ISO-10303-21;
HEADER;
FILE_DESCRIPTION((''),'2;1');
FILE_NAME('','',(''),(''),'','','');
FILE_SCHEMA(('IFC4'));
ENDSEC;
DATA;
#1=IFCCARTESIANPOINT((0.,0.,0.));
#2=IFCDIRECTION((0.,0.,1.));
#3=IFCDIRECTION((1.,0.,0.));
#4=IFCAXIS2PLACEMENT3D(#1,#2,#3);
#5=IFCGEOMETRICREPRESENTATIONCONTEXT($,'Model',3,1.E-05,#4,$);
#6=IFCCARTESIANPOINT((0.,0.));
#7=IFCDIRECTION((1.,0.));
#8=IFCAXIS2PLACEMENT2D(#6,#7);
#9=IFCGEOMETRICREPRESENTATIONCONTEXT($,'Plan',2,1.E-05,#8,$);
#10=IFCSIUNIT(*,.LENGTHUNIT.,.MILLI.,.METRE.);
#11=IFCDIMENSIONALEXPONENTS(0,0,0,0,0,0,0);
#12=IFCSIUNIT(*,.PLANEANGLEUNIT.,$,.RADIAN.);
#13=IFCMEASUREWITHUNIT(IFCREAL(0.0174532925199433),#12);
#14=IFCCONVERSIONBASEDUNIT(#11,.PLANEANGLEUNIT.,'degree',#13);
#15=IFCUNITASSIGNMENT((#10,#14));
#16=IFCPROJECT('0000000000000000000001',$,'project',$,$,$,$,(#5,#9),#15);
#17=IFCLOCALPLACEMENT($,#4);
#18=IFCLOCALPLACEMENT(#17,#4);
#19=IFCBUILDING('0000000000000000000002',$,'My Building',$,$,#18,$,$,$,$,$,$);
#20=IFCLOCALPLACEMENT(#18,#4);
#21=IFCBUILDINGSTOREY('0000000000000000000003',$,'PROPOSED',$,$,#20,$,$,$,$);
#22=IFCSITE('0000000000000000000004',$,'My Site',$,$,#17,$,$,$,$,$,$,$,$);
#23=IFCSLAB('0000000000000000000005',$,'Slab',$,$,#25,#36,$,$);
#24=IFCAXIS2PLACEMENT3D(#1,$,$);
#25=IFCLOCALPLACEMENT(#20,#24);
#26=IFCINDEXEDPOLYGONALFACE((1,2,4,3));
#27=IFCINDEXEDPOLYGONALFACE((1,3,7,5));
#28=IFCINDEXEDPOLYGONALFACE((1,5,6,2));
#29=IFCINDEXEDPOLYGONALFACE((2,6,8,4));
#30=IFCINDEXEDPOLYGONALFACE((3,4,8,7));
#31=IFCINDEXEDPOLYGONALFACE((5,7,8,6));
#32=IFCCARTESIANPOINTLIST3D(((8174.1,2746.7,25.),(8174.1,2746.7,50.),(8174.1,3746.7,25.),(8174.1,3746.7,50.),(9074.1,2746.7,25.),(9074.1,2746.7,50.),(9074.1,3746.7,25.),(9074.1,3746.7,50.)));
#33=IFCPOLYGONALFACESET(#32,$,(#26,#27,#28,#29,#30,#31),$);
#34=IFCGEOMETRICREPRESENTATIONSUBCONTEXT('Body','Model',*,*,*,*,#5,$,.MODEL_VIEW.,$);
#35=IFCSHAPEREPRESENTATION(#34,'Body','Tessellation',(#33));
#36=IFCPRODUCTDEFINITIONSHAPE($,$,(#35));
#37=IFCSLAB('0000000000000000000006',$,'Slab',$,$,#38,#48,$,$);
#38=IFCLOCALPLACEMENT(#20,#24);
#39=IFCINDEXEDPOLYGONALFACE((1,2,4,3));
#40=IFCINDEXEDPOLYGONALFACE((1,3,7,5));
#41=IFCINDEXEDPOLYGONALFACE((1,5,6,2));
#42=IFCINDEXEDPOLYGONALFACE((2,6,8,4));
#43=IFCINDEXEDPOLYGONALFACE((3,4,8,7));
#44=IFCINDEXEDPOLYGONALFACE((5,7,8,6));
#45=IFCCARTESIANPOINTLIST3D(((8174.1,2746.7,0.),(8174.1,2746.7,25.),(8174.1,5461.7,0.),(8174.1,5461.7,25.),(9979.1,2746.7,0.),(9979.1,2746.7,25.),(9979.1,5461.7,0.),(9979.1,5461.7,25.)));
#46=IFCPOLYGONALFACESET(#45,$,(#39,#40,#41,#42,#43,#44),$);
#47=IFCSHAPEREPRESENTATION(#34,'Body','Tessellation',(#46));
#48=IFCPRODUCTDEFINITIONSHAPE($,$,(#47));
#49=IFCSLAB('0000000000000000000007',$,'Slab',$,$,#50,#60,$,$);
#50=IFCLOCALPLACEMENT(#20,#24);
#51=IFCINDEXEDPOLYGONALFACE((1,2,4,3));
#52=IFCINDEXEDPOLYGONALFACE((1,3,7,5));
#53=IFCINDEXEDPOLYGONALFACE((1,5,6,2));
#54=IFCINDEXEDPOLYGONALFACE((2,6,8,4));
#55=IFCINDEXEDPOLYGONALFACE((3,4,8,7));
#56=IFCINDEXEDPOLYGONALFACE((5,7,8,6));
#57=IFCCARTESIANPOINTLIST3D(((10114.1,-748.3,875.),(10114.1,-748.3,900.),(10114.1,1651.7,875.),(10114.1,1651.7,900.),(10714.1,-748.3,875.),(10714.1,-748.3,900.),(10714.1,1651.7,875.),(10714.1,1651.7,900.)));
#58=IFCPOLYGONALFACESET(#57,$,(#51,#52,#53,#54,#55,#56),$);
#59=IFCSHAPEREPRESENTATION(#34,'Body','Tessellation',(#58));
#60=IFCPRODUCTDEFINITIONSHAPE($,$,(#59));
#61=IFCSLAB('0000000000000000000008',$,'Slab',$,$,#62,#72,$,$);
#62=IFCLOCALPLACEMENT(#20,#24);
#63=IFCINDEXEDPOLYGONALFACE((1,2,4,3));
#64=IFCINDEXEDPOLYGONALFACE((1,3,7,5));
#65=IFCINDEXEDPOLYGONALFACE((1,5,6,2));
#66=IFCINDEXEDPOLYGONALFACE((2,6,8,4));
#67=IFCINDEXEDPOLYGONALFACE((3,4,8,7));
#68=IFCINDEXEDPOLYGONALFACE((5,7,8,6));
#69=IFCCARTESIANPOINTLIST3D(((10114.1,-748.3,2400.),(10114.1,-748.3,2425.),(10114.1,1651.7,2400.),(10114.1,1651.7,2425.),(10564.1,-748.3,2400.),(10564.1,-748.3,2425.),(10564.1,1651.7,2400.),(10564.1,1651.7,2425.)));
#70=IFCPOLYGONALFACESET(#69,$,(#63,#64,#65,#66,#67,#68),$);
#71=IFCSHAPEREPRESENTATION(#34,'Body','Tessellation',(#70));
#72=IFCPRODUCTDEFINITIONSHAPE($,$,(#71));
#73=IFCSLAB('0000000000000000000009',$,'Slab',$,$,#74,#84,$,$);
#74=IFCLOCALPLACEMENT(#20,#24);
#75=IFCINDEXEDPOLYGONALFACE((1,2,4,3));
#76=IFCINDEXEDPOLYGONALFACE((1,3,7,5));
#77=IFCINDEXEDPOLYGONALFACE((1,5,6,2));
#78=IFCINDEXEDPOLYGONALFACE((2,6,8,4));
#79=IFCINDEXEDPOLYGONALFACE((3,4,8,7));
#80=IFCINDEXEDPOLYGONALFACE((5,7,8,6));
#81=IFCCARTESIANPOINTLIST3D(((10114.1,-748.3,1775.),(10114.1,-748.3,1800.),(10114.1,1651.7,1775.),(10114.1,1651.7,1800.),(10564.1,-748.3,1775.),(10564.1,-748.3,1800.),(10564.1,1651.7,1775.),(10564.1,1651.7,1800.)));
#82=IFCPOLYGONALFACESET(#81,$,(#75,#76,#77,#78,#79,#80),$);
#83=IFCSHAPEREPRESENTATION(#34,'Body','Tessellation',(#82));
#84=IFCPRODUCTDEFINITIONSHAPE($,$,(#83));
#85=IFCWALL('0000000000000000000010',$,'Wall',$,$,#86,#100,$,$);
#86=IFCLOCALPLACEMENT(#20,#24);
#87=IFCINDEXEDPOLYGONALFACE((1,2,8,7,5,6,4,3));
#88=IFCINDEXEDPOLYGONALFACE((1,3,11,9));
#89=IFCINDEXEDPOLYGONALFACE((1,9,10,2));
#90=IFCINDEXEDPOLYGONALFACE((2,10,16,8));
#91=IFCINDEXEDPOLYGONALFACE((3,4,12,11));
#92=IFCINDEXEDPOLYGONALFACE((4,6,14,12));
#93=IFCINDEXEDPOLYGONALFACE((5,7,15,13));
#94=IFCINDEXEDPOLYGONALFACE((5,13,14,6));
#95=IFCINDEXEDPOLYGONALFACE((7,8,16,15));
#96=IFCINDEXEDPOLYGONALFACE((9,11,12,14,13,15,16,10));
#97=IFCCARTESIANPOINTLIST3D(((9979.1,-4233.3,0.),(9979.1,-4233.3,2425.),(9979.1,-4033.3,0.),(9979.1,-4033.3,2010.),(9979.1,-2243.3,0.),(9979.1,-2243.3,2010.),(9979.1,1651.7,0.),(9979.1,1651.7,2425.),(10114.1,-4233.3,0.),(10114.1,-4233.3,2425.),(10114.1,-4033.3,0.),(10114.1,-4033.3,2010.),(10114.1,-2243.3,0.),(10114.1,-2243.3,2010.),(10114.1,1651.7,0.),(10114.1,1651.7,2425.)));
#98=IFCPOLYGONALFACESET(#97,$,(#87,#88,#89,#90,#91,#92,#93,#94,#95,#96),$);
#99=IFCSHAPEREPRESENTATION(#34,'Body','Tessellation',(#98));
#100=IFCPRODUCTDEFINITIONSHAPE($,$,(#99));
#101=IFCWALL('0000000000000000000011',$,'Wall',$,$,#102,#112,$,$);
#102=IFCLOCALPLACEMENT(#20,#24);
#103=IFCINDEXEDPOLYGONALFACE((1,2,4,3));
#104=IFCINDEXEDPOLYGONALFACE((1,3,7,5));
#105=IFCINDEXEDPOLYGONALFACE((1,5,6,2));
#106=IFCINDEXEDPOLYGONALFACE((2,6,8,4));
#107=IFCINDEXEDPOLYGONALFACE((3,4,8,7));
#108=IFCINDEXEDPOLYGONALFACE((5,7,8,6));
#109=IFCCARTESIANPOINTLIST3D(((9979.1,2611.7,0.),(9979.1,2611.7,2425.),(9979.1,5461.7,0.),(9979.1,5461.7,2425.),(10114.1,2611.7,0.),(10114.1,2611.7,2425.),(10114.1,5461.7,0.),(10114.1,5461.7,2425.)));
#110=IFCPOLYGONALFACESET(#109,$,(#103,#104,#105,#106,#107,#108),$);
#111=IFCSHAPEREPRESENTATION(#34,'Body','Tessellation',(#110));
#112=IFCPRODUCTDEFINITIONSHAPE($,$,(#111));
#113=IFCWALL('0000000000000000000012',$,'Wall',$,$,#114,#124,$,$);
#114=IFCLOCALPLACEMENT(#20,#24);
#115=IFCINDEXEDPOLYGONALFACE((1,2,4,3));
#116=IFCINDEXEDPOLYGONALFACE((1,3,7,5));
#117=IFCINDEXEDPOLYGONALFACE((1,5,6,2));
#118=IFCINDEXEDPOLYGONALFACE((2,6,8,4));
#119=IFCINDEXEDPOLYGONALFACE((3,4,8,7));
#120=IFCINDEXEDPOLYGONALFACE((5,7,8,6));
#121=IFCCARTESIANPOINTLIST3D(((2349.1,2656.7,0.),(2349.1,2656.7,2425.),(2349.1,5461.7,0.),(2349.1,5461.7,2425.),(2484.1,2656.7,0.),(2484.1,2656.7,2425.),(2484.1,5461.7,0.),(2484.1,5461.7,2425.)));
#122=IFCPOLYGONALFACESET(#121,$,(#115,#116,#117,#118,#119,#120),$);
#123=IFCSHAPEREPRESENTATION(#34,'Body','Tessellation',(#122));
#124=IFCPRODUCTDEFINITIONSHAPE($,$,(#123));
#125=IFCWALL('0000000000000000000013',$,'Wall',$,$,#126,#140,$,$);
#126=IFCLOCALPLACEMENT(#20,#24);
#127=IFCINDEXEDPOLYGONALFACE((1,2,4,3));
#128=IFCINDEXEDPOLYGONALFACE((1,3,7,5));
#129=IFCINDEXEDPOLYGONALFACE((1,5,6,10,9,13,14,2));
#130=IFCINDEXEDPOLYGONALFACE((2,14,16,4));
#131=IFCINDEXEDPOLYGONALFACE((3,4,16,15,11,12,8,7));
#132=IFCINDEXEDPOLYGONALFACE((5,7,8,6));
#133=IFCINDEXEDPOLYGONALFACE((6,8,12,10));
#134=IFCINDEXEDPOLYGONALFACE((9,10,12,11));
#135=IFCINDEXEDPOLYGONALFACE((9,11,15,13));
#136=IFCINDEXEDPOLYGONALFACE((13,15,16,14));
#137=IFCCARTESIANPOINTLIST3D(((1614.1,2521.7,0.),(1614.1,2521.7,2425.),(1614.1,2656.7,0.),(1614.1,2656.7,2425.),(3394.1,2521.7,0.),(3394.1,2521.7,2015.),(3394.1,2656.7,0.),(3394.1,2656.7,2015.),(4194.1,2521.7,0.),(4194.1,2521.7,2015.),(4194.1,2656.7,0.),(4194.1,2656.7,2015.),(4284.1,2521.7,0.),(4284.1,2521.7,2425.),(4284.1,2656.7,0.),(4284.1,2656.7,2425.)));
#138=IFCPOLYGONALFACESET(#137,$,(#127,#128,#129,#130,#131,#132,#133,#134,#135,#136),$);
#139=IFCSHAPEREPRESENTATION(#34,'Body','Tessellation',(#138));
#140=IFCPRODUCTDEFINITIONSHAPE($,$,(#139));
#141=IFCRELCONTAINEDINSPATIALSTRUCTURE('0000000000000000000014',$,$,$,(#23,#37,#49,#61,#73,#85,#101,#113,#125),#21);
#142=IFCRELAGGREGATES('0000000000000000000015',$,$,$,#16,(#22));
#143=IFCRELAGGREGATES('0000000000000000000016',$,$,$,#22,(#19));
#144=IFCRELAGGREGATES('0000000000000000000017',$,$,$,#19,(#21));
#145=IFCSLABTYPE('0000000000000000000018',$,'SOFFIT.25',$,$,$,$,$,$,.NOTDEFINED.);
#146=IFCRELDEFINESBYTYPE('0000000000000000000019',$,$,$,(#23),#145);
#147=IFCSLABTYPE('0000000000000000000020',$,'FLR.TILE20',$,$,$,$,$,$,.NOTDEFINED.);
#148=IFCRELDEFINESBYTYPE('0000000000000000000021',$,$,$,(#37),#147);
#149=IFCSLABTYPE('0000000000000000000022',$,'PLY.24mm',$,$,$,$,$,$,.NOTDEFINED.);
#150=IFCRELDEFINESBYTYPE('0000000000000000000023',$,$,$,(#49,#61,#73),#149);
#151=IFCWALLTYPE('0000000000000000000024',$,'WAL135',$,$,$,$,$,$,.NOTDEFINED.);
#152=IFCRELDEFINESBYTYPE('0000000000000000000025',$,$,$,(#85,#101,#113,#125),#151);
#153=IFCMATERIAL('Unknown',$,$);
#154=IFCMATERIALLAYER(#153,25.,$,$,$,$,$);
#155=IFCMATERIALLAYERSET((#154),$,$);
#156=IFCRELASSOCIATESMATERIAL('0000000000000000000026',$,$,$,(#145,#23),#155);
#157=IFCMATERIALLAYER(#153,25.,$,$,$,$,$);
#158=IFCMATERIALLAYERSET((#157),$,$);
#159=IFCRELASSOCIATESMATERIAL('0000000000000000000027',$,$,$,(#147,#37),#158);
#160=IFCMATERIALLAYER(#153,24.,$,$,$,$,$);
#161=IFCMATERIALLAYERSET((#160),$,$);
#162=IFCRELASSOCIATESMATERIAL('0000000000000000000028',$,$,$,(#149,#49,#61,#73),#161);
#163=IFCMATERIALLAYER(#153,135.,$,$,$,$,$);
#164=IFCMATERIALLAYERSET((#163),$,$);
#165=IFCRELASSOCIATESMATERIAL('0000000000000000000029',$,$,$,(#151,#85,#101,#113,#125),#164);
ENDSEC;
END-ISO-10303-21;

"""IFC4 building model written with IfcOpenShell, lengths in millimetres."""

from ifc_helpers import new_model, entity, si_unit, converted_unit, frame, origin_with_axes, origin_2d_with_axis, place, context, subcontext, project, spatial, line, indexed_curve, outline, extrude, source, transform, mapped, material, layer, layer_set, layer_usage, type_object, element, save


model = new_model("IFC4")

# Units and contexts
model_context = context("Model", 3, precision=1e-05, world=origin_with_axes())
plan_context = context("Plan", 2, precision=1e-05, world=origin_2d_with_axis())
body_context_1 = subcontext(model_context, "Body", "Model", "MODEL_VIEW")
ifc_project = project(units=[si_unit("LENGTHUNIT", "METRE", prefix="MILLI"), converted_unit("PLANEANGLEUNIT", "degree", entity("IfcReal", 0.0174532925199433), si_unit("PLANEANGLEUNIT", "RADIAN"), dimensions=[0, 0, 0, 0, 0, 0, 0])], contexts=[model_context, plan_context])

# Site, building, storey
site_placement = place(None, origin_with_axes())
site = spatial("IfcSite", under=ifc_project, at=site_placement, Name="My Site")
building_placement = place(site_placement, origin_with_axes())
building = spatial("IfcBuilding", under=site, at=building_placement, Name="My Building")
storey_placement = place(building_placement, origin_with_axes())
storey = spatial("IfcBuildingStorey", under=building, at=storey_placement, Name="PROPOSED")

# Slabs
ifc_material = material(Name="Unknown")
ifc_layer_1 = layer(ifc_material, 25.0)
ifc_layer_set_1 = layer_set([ifc_layer_1])
ifc_layer_usage_1 = layer_usage(ifc_layer_set_1, "AXIS3", "POSITIVE", 0.0)
slab_type_1 = type_object("IfcSlabType", Name="SOFFIT.25", PredefinedType="NOTDEFINED", material=ifc_layer_set_1)
slab_1_placement = place(storey_placement, frame((8174.1, 2746.7, 25.0), z_axis=(0.0, 0.0, 1.0), x_axis=(1.0, 0.0, 0.0)))
element("IfcSlab", 1, at=slab_1_placement, inside=storey, type_object=slab_type_1, material=ifc_layer_usage_1, Name="Slab", context=body_context_1, shape_type="SweptSolid", body=[
    extrude(outline(indexed_curve([(0.0, 0.0), (900.0, 0.0), (900.0, 1000.0), (0.0, 1000.0)], segments=[line(3, 2), line(2, 1), line(1, 4), line(4, 3)], self_intersect=False)), None, (0.0, 0.0, 1.0), 25.0),
])
ifc_layer_2 = layer(ifc_material, 25.0)
ifc_layer_set_2 = layer_set([ifc_layer_2])
ifc_layer_usage_2 = layer_usage(ifc_layer_set_2, "AXIS3", "POSITIVE", 0.0)
slab_type_2 = type_object("IfcSlabType", Name="FLR.TILE20", PredefinedType="NOTDEFINED", material=ifc_layer_set_2)
slab_2_placement = place(storey_placement, frame((8174.1, 2746.7, 0.0), z_axis=(0.0, 0.0, 1.0), x_axis=(1.0, 0.0, 0.0)))
element("IfcSlab", 2, at=slab_2_placement, inside=storey, type_object=slab_type_2, material=ifc_layer_usage_2, Name="Slab", context=body_context_1, shape_type="SweptSolid", body=[
    extrude(outline(indexed_curve([(0.0, 0.0), (1805.0, 0.0), (1805.0, 2715.0), (0.0, 2715.0)], segments=[line(3, 2), line(2, 1), line(1, 4), line(4, 3)], self_intersect=False)), None, (0.0, 0.0, 1.0), 25.0),
])
ifc_layer_3 = layer(ifc_material, 24.0)
ifc_layer_set_3 = layer_set([ifc_layer_3])
ifc_layer_usage_3 = layer_usage(ifc_layer_set_3, "AXIS3", "POSITIVE", 0.0)
slab_type_3 = type_object("IfcSlabType", Name="PLY.24mm", PredefinedType="NOTDEFINED", material=ifc_layer_set_3)
slab_3_placement = place(storey_placement, frame((10114.1, -748.3, 875.0), z_axis=(0.0, 0.0, 1.0), x_axis=(1.0, 0.0, 0.0)))
element("IfcSlab", 3, at=slab_3_placement, inside=storey, type_object=slab_type_3, material=ifc_layer_usage_3, Name="Slab", context=body_context_1, shape_type="SweptSolid", body=[
    extrude(outline(indexed_curve([(0.0, 2400.0), (600.0, 2400.0), (600.0, 0.0), (0.0, 0.0)], segments=[line(3, 2), line(2, 1), line(1, 4), line(4, 3)], self_intersect=False)), None, (0.0, 0.0, 1.0), 25.0),
])
ifc_layer_usage_4 = layer_usage(ifc_layer_set_3, "AXIS3", "POSITIVE", 0.0)
slab_4_placement = place(storey_placement, frame((10114.1, -748.3, 2400.0), z_axis=(0.0, 0.0, 1.0), x_axis=(1.0, 0.0, 0.0)))
element("IfcSlab", 4, at=slab_4_placement, inside=storey, type_object=slab_type_3, material=ifc_layer_usage_4, Name="Slab", context=body_context_1, shape_type="SweptSolid", body=[
    extrude(outline(indexed_curve([(450.0, 0.0), (450.0, 2400.0), (0.0, 2400.0), (0.0, 0.0)], segments=[line(4, 1), line(1, 2), line(2, 3), line(3, 4)], self_intersect=False)), None, (0.0, 0.0, 1.0), 25.0),
])
ifc_layer_usage_5 = layer_usage(ifc_layer_set_3, "AXIS3", "POSITIVE", 0.0)
slab_5_placement = place(storey_placement, frame((10114.1, -748.3, 1775.0), z_axis=(0.0, 0.0, 1.0), x_axis=(1.0, 0.0, 0.0)))
element("IfcSlab", 5, at=slab_5_placement, inside=storey, type_object=slab_type_3, material=ifc_layer_usage_5, Name="Slab", context=body_context_1, shape_type="SweptSolid", body=[
    extrude(outline(indexed_curve([(450.0, 0.0), (450.0, 2400.0), (0.0, 2400.0), (0.0, 0.0)], segments=[line(3, 2), line(2, 1), line(1, 4), line(4, 3)], self_intersect=False)), None, (0.0, 0.0, 1.0), 25.0),
])

# Wall, opening
ifc_layer_4 = layer(ifc_material, 135.0)
ifc_layer_set_4 = layer_set([ifc_layer_4])
ifc_layer_usage_6 = layer_usage(ifc_layer_set_4, "AXIS2", "POSITIVE", 0.0)
wall_type_1 = type_object("IfcWallType", Name="WAL135", PredefinedType="NOTDEFINED", material=ifc_layer_set_4)
wall_1_placement = place(storey_placement, frame((9979.1, 1651.7, 0.0), z_axis=(0.0, 0.0, 1.0), x_axis=(0.0, -1.0, 0.0)))
wall_1 = element("IfcWall", 6, at=wall_1_placement, inside=storey, type_object=wall_type_1, material=ifc_layer_usage_6, Name="Wall", context=body_context_1, shape_type="SweptSolid", body=[
    extrude(outline(indexed_curve([(0.0, 0.0), (0.0, 135.0), (5885.0, 135.0), (5885.0, 0.0), (0.0, 0.0)], self_intersect=False)), origin_with_axes(), (0.0, 0.0, 1.0), 2425.0),
])
shared_shape_1 = source(origin_with_axes(), body_context_1, "Body", "SweptSolid", [
    extrude(outline(indexed_curve([(0.0, 0.0), (1790.0, 0.0), (1790.0, 2010.0), (0.0, 2010.0)], segments=[line(1, 2, 3, 4, 1)])), frame((0.0, -600.0, 0.0), z_axis=(0.0, -1.0, 0.0), x_axis=(1.0, 0.0, 0.0)), (0.0, 0.0, -1.0), 1200.0),
])
opening_1_placement = place(wall_1_placement, frame((3895.0, 100.0, 0.0), z_axis=(0.0, 0.0, 1.0), x_axis=(1.0, 0.0, 0.0)))
element("IfcOpeningElement", 7, at=opening_1_placement, cuts=wall_1, PredefinedType="OPENING", context=body_context_1, shape_type="MappedRepresentation", body=[
    mapped(shared_shape_1, transform((0.0, 0.0, 0.0), x_axis=(1.0, 0.0, 0.0), y_axis=(0.0, 1.0, 0.0), z_axis=(0.0, 0.0, 1.0), scale=1.0)),
])

# Walls
ifc_layer_usage_7 = layer_usage(ifc_layer_set_4, "AXIS2", "POSITIVE", 0.0)
wall_2_placement = place(storey_placement, frame((10114.1, 2611.7, 0.0), z_axis=(0.0, 0.0, 1.0), x_axis=(0.0, 1.0, 0.0)))
element("IfcWall", 8, at=wall_2_placement, inside=storey, type_object=wall_type_1, material=ifc_layer_usage_7, Name="Wall", context=body_context_1, shape_type="SweptSolid", body=[
    extrude(outline(indexed_curve([(0.0, 0.0), (0.0, 135.0), (2850.0, 135.0), (2850.0, 0.0), (0.0, 0.0)], self_intersect=False)), origin_with_axes(), (0.0, 0.0, 1.0), 2425.0),
])
ifc_layer_usage_8 = layer_usage(ifc_layer_set_4, "AXIS2", "POSITIVE", 0.0)
wall_3_placement = place(storey_placement, frame((2484.1, 2656.7, 0.0), z_axis=(0.0, 0.0, 1.0), x_axis=(0.0, 1.0, 0.0)))
element("IfcWall", 9, at=wall_3_placement, inside=storey, type_object=wall_type_1, material=ifc_layer_usage_8, Name="Wall", context=body_context_1, shape_type="SweptSolid", body=[
    extrude(outline(indexed_curve([(0.0, 0.0), (0.0, 135.0), (2805.0, 135.0), (2805.0, 0.0), (0.0, 0.0)], self_intersect=False)), origin_with_axes(), (0.0, 0.0, 1.0), 2425.0),
])

# Wall, opening
ifc_layer_usage_9 = layer_usage(ifc_layer_set_4, "AXIS2", "POSITIVE", 0.0)
wall_4_placement = place(storey_placement, frame((1614.1, 2521.7, 0.0), z_axis=(0.0, 0.0, 1.0), x_axis=(1.0, 0.0, 0.0)))
wall_4 = element("IfcWall", 10, at=wall_4_placement, inside=storey, type_object=wall_type_1, material=ifc_layer_usage_9, Name="Wall", context=body_context_1, shape_type="SweptSolid", body=[
    extrude(outline(indexed_curve([(0.0, 0.0), (0.0, 135.0), (2670.0, 135.0), (2670.0, 0.0), (0.0, 0.0)], self_intersect=False)), origin_with_axes(), (0.0, 0.0, 1.0), 2425.0),
])
shared_shape_2 = source(origin_with_axes(), body_context_1, "Body", "SweptSolid", [
    extrude(outline(indexed_curve([(0.0, 0.0), (800.0, 0.0), (800.0, 2015.0), (0.0, 2015.0)], segments=[line(1, 2, 3, 4, 1)])), frame((0.0, -600.0, 0.0), z_axis=(0.0, -1.0, 0.0), x_axis=(1.0, 0.0, 0.0)), (0.0, 0.0, -1.0), 1200.0),
])
opening_2_placement = place(wall_4_placement, frame((1780.0, 78.7, 0.0), z_axis=(0.0, 0.0, 1.0), x_axis=(1.0, 0.0, 0.0)))
element("IfcOpeningElement", 11, at=opening_2_placement, cuts=wall_4, PredefinedType="OPENING", context=body_context_1, shape_type="MappedRepresentation", body=[
    mapped(shared_shape_2, transform((0.0, 0.0, 0.0), x_axis=(1.0, 0.0, 0.0), y_axis=(0.0, 1.0, 0.0), z_axis=(0.0, 0.0, 1.0), scale=1.0)),
])

save(model, "model.ifc")
